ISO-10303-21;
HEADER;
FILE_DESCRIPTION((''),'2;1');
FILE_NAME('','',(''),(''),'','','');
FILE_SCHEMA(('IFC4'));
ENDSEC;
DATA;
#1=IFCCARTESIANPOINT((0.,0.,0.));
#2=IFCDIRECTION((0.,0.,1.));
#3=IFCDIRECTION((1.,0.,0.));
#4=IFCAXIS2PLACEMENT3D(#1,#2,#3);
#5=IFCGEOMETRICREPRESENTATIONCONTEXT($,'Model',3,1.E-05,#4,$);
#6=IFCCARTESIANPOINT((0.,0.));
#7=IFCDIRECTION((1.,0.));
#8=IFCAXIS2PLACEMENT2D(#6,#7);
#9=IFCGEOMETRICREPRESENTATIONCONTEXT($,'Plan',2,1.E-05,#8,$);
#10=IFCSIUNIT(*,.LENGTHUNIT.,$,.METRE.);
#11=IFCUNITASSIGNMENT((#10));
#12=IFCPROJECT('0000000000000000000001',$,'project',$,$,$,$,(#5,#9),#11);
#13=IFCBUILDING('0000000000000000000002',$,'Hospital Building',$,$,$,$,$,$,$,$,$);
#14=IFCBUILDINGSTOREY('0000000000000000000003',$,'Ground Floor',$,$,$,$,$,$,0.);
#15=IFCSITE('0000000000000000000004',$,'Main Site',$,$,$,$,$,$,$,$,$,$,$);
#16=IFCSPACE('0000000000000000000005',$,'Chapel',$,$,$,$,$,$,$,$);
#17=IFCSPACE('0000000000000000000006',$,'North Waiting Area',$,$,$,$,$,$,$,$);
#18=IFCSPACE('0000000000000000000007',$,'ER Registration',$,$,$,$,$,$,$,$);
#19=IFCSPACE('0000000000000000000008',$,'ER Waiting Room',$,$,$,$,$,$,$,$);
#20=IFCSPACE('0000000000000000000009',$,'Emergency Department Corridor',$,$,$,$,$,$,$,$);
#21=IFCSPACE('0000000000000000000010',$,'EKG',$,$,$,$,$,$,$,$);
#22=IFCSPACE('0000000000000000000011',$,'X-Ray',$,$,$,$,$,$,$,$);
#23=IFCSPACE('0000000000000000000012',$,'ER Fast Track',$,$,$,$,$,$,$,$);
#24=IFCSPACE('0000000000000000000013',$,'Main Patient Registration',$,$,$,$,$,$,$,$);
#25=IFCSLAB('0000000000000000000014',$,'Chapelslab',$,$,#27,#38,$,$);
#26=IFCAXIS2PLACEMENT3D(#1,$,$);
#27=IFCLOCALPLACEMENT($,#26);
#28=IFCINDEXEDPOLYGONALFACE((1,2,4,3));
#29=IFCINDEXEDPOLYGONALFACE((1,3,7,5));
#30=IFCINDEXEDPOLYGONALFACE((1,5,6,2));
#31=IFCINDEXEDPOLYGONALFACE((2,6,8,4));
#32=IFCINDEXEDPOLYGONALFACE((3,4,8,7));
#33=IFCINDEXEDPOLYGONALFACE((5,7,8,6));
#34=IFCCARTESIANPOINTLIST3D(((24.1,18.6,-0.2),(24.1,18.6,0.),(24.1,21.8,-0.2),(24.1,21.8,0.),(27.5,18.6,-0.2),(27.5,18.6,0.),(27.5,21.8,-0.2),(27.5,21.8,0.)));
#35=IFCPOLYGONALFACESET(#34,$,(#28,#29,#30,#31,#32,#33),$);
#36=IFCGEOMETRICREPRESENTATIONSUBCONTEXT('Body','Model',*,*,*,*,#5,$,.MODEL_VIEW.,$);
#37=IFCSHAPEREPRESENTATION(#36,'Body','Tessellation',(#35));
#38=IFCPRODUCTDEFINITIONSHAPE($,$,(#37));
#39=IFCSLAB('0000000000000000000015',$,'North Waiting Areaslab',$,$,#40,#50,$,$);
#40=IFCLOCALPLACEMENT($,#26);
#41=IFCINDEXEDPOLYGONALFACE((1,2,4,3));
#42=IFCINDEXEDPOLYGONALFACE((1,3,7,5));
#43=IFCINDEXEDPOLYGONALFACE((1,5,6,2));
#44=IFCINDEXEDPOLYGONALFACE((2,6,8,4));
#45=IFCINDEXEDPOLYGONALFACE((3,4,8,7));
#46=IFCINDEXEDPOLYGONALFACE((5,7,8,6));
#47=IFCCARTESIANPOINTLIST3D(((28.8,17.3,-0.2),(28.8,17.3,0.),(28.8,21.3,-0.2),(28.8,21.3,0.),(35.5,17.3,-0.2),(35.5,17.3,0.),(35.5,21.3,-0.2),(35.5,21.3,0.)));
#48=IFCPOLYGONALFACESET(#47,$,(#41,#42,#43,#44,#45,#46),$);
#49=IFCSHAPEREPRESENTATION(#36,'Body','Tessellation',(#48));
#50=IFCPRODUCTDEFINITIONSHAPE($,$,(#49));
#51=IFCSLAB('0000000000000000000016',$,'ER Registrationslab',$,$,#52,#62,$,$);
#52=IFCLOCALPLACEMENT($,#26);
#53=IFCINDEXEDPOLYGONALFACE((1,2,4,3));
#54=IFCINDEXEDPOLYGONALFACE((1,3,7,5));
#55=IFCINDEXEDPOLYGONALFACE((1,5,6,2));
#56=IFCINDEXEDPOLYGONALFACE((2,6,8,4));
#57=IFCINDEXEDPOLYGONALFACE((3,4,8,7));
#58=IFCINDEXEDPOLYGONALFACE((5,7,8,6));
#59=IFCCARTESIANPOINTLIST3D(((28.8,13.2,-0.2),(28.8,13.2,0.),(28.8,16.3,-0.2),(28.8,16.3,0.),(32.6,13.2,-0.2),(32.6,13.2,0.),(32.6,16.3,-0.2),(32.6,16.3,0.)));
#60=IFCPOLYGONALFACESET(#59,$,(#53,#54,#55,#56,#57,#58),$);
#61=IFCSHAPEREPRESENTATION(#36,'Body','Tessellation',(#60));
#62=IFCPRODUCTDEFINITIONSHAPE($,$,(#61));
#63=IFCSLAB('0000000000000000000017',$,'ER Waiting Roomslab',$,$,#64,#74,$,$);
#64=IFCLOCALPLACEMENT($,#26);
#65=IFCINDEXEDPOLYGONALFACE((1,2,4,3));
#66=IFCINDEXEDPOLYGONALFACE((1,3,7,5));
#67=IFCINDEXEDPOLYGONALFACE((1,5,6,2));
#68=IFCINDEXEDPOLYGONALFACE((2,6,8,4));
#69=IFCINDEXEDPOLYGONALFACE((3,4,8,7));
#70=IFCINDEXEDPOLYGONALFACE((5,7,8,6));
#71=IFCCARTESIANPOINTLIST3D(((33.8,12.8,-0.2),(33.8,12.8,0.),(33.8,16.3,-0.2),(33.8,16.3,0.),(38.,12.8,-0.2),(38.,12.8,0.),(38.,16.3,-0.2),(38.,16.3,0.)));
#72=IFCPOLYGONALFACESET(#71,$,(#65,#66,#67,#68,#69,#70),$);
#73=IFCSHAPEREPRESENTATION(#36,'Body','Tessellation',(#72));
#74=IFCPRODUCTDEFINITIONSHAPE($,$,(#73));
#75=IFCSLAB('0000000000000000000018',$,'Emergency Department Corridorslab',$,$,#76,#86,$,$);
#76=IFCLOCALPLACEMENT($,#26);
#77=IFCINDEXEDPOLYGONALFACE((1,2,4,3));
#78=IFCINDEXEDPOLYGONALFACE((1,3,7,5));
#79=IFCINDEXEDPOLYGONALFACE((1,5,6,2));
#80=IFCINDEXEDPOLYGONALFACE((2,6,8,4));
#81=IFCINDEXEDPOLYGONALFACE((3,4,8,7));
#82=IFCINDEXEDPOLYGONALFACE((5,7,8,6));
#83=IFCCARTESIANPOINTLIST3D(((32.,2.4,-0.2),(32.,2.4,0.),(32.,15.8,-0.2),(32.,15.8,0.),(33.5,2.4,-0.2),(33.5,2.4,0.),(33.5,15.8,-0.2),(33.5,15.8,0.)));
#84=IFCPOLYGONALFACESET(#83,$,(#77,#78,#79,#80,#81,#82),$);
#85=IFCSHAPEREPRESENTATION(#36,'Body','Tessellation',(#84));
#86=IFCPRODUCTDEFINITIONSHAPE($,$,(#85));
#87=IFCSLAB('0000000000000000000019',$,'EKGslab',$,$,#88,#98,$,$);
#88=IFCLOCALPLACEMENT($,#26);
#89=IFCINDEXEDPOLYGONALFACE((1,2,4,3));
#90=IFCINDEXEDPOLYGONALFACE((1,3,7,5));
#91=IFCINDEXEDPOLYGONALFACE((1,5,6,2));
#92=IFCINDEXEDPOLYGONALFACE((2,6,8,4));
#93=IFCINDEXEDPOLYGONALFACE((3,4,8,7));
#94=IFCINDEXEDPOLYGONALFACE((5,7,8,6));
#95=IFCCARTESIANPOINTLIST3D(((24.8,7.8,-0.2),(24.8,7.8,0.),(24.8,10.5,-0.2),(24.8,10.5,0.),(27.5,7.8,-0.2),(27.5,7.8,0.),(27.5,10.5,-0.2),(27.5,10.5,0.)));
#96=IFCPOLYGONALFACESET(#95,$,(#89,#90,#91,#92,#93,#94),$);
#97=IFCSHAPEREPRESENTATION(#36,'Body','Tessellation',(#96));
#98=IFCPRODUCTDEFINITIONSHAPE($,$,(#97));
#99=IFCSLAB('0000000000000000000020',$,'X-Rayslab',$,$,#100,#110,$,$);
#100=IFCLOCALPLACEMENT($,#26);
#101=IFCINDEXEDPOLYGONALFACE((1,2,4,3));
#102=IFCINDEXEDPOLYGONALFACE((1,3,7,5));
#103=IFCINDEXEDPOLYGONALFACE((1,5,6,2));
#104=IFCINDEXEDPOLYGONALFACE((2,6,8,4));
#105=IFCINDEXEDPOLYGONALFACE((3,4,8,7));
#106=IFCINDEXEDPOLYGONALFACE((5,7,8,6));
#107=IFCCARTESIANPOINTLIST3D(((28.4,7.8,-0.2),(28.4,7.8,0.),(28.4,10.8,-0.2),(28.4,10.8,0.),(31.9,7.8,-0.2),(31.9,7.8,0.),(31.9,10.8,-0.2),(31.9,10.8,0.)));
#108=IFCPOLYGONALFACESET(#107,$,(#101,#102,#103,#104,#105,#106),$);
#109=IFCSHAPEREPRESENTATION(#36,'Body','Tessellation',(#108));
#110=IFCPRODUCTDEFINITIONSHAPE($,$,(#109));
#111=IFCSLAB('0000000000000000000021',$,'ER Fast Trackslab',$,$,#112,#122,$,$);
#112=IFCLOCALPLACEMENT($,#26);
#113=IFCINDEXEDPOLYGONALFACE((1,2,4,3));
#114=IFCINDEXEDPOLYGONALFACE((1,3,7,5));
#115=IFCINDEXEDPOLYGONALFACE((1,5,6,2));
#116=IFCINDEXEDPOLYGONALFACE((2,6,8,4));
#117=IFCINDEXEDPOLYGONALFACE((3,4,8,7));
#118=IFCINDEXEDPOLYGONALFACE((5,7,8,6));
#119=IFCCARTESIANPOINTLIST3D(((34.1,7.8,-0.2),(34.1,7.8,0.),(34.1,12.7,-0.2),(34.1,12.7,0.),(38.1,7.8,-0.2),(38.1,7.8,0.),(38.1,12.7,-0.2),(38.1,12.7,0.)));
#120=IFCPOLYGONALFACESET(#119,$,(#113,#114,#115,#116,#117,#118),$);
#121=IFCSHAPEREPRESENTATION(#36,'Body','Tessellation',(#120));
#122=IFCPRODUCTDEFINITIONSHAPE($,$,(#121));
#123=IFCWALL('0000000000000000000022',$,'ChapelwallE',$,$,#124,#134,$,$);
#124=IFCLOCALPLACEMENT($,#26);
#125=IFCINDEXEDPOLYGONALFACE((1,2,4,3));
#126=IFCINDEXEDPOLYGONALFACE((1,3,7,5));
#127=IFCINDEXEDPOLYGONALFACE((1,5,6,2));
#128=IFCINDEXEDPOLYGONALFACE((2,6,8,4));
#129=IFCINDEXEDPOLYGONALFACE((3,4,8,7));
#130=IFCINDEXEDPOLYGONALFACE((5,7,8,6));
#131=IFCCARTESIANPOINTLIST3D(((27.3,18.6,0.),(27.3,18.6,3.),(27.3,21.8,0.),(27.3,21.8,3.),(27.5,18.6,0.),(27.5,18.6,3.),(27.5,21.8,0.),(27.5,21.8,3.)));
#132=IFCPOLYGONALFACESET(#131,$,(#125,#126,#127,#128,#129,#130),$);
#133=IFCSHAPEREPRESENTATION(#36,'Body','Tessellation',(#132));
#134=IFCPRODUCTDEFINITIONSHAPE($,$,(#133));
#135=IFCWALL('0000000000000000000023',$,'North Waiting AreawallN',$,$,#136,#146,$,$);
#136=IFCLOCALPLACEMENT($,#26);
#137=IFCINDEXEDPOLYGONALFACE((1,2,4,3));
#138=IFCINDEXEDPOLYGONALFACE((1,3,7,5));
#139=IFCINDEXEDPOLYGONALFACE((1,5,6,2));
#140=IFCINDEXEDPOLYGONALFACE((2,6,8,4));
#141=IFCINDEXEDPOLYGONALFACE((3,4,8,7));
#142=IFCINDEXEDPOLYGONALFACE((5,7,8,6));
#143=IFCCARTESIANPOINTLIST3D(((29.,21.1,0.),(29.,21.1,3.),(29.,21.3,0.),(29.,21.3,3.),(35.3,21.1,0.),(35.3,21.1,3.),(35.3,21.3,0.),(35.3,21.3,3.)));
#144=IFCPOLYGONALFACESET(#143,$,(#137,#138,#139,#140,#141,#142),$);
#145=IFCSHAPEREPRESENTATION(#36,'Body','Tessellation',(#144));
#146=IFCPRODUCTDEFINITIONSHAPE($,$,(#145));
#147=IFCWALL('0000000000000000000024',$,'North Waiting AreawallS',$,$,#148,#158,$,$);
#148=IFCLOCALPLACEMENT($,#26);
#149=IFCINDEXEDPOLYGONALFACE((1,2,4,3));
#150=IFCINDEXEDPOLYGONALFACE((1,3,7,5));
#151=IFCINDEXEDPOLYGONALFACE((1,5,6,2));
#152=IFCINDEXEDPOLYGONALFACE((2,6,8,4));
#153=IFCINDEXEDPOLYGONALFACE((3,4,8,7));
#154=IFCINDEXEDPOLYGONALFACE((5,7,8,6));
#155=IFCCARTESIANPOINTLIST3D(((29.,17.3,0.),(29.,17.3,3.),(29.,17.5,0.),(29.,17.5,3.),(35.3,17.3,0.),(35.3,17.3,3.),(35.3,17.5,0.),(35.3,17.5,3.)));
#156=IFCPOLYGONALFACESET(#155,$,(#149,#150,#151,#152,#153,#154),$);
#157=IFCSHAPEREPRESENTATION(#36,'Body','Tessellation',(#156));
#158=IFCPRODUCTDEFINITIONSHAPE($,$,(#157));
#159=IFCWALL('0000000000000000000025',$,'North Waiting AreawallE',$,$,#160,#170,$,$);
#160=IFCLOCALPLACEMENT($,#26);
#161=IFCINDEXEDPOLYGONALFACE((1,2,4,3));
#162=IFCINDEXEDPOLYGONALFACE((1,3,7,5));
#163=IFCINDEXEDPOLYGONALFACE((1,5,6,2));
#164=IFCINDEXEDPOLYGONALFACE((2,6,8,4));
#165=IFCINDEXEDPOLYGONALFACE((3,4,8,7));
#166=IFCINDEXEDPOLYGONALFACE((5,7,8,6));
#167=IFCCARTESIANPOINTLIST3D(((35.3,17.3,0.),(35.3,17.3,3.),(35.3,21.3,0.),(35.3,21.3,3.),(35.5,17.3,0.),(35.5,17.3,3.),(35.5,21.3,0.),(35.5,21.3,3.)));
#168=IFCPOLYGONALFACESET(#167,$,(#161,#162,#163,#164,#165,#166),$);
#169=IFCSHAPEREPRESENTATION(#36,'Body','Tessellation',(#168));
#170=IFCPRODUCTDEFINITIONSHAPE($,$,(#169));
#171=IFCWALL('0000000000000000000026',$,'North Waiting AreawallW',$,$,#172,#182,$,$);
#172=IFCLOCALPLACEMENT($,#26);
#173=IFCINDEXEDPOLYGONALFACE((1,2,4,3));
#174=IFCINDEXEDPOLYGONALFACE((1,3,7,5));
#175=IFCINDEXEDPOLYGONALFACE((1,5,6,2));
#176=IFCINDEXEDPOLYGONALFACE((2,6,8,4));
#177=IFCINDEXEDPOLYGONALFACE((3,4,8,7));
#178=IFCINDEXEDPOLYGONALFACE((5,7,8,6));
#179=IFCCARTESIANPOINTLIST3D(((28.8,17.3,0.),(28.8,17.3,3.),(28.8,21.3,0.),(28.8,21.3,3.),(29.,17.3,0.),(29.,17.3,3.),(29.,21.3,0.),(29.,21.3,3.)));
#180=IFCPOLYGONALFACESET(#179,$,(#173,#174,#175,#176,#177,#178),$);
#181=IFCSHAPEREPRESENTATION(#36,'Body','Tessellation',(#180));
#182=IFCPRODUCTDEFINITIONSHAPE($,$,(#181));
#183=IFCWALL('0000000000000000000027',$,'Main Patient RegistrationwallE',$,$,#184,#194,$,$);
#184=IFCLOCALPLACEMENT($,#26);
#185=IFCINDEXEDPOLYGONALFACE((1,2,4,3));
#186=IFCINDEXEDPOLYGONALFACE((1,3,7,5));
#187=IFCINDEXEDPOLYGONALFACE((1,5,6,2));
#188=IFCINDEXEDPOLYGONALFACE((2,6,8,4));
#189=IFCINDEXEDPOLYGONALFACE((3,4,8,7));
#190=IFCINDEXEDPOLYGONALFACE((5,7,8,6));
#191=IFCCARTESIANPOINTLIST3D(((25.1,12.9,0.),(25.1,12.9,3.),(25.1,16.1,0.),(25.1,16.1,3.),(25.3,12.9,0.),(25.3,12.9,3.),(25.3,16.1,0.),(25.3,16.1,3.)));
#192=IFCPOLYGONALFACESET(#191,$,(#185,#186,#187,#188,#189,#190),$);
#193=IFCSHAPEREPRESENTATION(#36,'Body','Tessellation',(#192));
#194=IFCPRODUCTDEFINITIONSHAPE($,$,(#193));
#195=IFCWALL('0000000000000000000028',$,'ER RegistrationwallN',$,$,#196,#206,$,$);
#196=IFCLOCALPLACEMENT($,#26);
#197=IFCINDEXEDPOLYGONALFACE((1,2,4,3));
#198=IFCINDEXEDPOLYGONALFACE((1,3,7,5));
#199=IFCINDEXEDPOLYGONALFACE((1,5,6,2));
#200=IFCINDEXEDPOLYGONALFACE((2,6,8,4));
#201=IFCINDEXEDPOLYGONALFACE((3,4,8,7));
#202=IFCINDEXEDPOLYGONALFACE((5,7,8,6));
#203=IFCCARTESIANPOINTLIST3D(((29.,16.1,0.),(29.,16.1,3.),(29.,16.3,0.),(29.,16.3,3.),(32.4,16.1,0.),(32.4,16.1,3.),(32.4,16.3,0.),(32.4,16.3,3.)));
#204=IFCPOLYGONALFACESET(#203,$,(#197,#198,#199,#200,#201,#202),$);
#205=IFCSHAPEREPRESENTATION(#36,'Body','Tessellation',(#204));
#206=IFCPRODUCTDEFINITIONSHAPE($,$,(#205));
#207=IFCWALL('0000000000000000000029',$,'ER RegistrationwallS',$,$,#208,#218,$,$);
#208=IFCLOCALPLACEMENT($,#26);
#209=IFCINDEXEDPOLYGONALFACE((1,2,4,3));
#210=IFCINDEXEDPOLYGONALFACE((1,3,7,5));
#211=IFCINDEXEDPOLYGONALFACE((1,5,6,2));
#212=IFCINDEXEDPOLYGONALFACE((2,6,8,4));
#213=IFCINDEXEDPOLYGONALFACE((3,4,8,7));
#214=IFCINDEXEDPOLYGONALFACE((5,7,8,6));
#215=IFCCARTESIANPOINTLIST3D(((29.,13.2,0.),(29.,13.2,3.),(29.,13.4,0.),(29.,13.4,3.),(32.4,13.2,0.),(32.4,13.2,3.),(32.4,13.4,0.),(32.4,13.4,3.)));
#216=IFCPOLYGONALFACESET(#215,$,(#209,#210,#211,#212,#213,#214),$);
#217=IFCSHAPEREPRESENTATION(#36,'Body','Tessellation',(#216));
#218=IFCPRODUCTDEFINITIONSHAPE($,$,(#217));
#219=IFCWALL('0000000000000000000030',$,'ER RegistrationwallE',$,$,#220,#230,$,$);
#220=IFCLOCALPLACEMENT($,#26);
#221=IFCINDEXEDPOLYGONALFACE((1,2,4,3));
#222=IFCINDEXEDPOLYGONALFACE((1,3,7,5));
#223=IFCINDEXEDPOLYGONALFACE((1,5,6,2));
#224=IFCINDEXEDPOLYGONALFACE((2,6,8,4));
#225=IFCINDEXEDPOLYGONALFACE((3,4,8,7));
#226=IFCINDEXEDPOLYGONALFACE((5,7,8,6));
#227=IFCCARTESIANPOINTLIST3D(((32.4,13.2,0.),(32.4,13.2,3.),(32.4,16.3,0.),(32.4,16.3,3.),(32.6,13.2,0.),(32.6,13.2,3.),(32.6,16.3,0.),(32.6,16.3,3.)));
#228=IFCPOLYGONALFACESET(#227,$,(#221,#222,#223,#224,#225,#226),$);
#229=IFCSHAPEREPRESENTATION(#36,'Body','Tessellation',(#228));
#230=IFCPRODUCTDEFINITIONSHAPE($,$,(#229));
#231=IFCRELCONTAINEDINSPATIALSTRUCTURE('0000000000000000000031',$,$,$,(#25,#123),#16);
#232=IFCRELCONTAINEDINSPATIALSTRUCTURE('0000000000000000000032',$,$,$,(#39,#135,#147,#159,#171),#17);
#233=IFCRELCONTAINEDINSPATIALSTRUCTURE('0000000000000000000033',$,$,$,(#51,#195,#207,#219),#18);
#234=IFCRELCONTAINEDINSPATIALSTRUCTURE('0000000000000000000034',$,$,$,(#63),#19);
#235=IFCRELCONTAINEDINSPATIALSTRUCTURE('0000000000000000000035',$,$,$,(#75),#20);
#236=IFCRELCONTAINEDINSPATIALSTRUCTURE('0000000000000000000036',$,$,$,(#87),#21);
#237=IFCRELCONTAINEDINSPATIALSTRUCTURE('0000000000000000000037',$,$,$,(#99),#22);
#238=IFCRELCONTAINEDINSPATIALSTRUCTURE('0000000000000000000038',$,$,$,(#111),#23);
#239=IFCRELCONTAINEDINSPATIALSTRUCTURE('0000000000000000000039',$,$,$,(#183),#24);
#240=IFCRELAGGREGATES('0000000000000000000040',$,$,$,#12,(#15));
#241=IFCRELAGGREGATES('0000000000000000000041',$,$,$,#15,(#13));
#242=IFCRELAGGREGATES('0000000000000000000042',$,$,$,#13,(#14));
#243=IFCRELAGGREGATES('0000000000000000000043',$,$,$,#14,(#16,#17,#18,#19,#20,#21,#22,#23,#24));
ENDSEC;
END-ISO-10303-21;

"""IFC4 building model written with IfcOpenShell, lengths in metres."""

from ifc_helpers import new_model, si_unit, frame, origin_with_axes, origin_2d_with_axis, place, context, subcontext, project, spatial, indexed_curve, rectangle, outline, extrude, element, save


model = new_model("IFC4")

# Units and contexts
model_context = context("Model", 3, precision=1e-05, world=origin_with_axes())
plan_context = context("Plan", 2, precision=1e-05, world=origin_2d_with_axis())
body_context = subcontext(model_context, "Body", "Model", "MODEL_VIEW")
ifc_project = project(units=[si_unit("LENGTHUNIT", "METRE")], contexts=[model_context, plan_context])

# Site, building, storey, space
site = spatial("IfcSite", under=ifc_project, Name="Main Site")
building = spatial("IfcBuilding", under=site, Name="Hospital Building")
storey = spatial("IfcBuildingStorey", under=building, Name="Ground Floor", Elevation=0.0)
space_1 = spatial("IfcSpace", under=storey, Name="Chapel")

# Slab
slab_1_placement = place(None, frame((25.8, 20.2, -0.2), z_axis=(0.0, 0.0, 1.0), x_axis=(1.0, 0.0, 0.0)))
element("IfcSlab", 1, at=slab_1_placement, inside=space_1, Name="Chapelslab", context=body_context, shape_type="SweptSolid", body=[
    extrude(rectangle(XDim=3.4, YDim=3.2), origin_with_axes(), (0.0, 0.0, 1.0), 0.2),
])

# Shared definitions
space_2 = spatial("IfcSpace", under=storey, Name="North Waiting Area")

# Slab
slab_2_placement = place(None, frame((32.15, 19.3, -0.2), z_axis=(0.0, 0.0, 1.0), x_axis=(1.0, 0.0, 0.0)))
element("IfcSlab", 2, at=slab_2_placement, inside=space_2, Name="North Waiting Areaslab", context=body_context, shape_type="SweptSolid", body=[
    extrude(rectangle(XDim=6.7, YDim=4.0), origin_with_axes(), (0.0, 0.0, 1.0), 0.2),
])

# Shared definitions
space_3 = spatial("IfcSpace", under=storey, Name="ER Registration")

# Slab
slab_3_placement = place(None, frame((30.7, 14.75, -0.2), z_axis=(0.0, 0.0, 1.0), x_axis=(1.0, 0.0, 0.0)))
element("IfcSlab", 3, at=slab_3_placement, inside=space_3, Name="ER Registrationslab", context=body_context, shape_type="SweptSolid", body=[
    extrude(rectangle(XDim=3.8, YDim=3.1), origin_with_axes(), (0.0, 0.0, 1.0), 0.2),
])

# Shared definitions
space_4 = spatial("IfcSpace", under=storey, Name="ER Waiting Room")

# Slab
slab_4_placement = place(None, frame((35.9, 14.55, -0.2), z_axis=(0.0, 0.0, 1.0), x_axis=(1.0, 0.0, 0.0)))
element("IfcSlab", 4, at=slab_4_placement, inside=space_4, Name="ER Waiting Roomslab", context=body_context, shape_type="SweptSolid", body=[
    extrude(rectangle(XDim=4.2, YDim=3.5), origin_with_axes(), (0.0, 0.0, 1.0), 0.2),
])

# Shared definitions
space_5 = spatial("IfcSpace", under=storey, Name="Emergency Department Corridor")

# Slab
slab_5_placement = place(None, frame((32.75, 9.1, -0.2), z_axis=(0.0, 0.0, 1.0), x_axis=(1.0, 0.0, 0.0)))
element("IfcSlab", 5, at=slab_5_placement, inside=space_5, Name="Emergency Department Corridorslab", context=body_context, shape_type="SweptSolid", body=[
    extrude(rectangle(XDim=1.5, YDim=13.4), origin_with_axes(), (0.0, 0.0, 1.0), 0.2),
])

# Shared definitions
space_6 = spatial("IfcSpace", under=storey, Name="EKG")

# Slab
slab_6_placement = place(None, frame((26.15, 9.15, -0.2), z_axis=(0.0, 0.0, 1.0), x_axis=(1.0, 0.0, 0.0)))
element("IfcSlab", 6, at=slab_6_placement, inside=space_6, Name="EKGslab", context=body_context, shape_type="SweptSolid", body=[
    extrude(rectangle(XDim=2.7, YDim=2.7), origin_with_axes(), (0.0, 0.0, 1.0), 0.2),
])

# Shared definitions
space_7 = spatial("IfcSpace", under=storey, Name="X-Ray")

# Slab
slab_7_placement = place(None, frame((30.15, 9.3, -0.2), z_axis=(0.0, 0.0, 1.0), x_axis=(1.0, 0.0, 0.0)))
element("IfcSlab", 7, at=slab_7_placement, inside=space_7, Name="X-Rayslab", context=body_context, shape_type="SweptSolid", body=[
    extrude(rectangle(XDim=3.5, YDim=3.0), origin_with_axes(), (0.0, 0.0, 1.0), 0.2),
])

# Shared definitions
space_8 = spatial("IfcSpace", under=storey, Name="ER Fast Track")

# Slab
slab_8_placement = place(None, frame((36.1, 10.25, -0.2), z_axis=(0.0, 0.0, 1.0), x_axis=(1.0, 0.0, 0.0)))
element("IfcSlab", 8, at=slab_8_placement, inside=space_8, Name="ER Fast Trackslab", context=body_context, shape_type="SweptSolid", body=[
    extrude(rectangle(XDim=4.0, YDim=4.9), origin_with_axes(), (0.0, 0.0, 1.0), 0.2),
])

# Walls
wall_1_placement = place(None, frame((27.5, 18.6, 0.0), z_axis=(0.0, 0.0, 1.0), x_axis=(0.0, 1.0, 0.0)))
element("IfcWall", 9, at=wall_1_placement, inside=space_1, Name="ChapelwallE", context=body_context, shape_type="SweptSolid", body=[
    extrude(outline(indexed_curve([(0.0, 0.0), (0.0, 0.2), (3.2, 0.2), (3.2, 0.0), (0.0, 0.0)], self_intersect=False)), origin_with_axes(), (0.0, 0.0, 1.0), 3.0),
])
for number, where, z_axis, x_axis, name in (
    (10, (29.0, 21.1, 0.0), (0.0, 0.0, 1.0), (1.0, 0.0, 0.0), "North Waiting AreawallN"),
    (11, (29.0, 17.3, 0.0), (0.0, 0.0, 1.0), (1.0, 0.0, 0.0), "North Waiting AreawallS"),
):
    element("IfcWall", number, at=place(None, frame(where, z_axis=z_axis, x_axis=x_axis)), inside=space_2, Name=name, context=body_context, shape_type="SweptSolid", body=[
        extrude(outline(indexed_curve([(0.0, 0.0), (0.0, 0.2), (6.3, 0.2), (6.3, 0.0), (0.0, 0.0)], self_intersect=False)), origin_with_axes(), (0.0, 0.0, 1.0), 3.0),
    ])
for number, where, z_axis, x_axis, name in (
    (12, (35.5, 17.3, 0.0), (0.0, 0.0, 1.0), (0.0, 1.0, 0.0), "North Waiting AreawallE"),
    (13, (29.0, 17.3, 0.0), (0.0, 0.0, 1.0), (0.0, 1.0, 0.0), "North Waiting AreawallW"),
):
    element("IfcWall", number, at=place(None, frame(where, z_axis=z_axis, x_axis=x_axis)), inside=space_2, Name=name, context=body_context, shape_type="SweptSolid", body=[
        extrude(outline(indexed_curve([(0.0, 0.0), (0.0, 0.2), (4.0, 0.2), (4.0, 0.0), (0.0, 0.0)], self_intersect=False)), origin_with_axes(), (0.0, 0.0, 1.0), 3.0),
    ])

# Shared definitions
space_9 = spatial("IfcSpace", under=storey, Name="Main Patient Registration")

# Walls
wall_2_placement = place(None, frame((25.3, 12.9, 0.0), z_axis=(0.0, 0.0, 1.0), x_axis=(0.0, 1.0, 0.0)))
element("IfcWall", 14, at=wall_2_placement, inside=space_9, Name="Main Patient RegistrationwallE", context=body_context, shape_type="SweptSolid", body=[
    extrude(outline(indexed_curve([(0.0, 0.0), (0.0, 0.2), (3.2, 0.2), (3.2, 0.0), (0.0, 0.0)], self_intersect=False)), origin_with_axes(), (0.0, 0.0, 1.0), 3.0),
])
for number, where, z_axis, x_axis, name in (
    (15, (29.0, 16.1, 0.0), (0.0, 0.0, 1.0), (1.0, 0.0, 0.0), "ER RegistrationwallN"),
    (16, (29.0, 13.2, 0.0), (0.0, 0.0, 1.0), (1.0, 0.0, 0.0), "ER RegistrationwallS"),
):
    element("IfcWall", number, at=place(None, frame(where, z_axis=z_axis, x_axis=x_axis)), inside=space_3, Name=name, context=body_context, shape_type="SweptSolid", body=[
        extrude(outline(indexed_curve([(0.0, 0.0), (0.0, 0.2), (3.4, 0.2), (3.4, 0.0), (0.0, 0.0)], self_intersect=False)), origin_with_axes(), (0.0, 0.0, 1.0), 3.0),
    ])
for number, where, z_axis, x_axis, name in (
    (17, (32.6, 13.2, 0.0), (0.0, 0.0, 1.0), (0.0, 1.0, 0.0), "ER RegistrationwallE"),
):
    element("IfcWall", number, at=place(None, frame(where, z_axis=z_axis, x_axis=x_axis)), inside=space_3, Name=name, context=body_context, shape_type="SweptSolid", body=[
        extrude(outline(indexed_curve([(0.0, 0.0), (0.0, 0.2), (3.1, 0.2), (3.1, 0.0), (0.0, 0.0)], self_intersect=False)), origin_with_axes(), (0.0, 0.0, 1.0), 3.0),
    ])

save(model, "model.ifc")
